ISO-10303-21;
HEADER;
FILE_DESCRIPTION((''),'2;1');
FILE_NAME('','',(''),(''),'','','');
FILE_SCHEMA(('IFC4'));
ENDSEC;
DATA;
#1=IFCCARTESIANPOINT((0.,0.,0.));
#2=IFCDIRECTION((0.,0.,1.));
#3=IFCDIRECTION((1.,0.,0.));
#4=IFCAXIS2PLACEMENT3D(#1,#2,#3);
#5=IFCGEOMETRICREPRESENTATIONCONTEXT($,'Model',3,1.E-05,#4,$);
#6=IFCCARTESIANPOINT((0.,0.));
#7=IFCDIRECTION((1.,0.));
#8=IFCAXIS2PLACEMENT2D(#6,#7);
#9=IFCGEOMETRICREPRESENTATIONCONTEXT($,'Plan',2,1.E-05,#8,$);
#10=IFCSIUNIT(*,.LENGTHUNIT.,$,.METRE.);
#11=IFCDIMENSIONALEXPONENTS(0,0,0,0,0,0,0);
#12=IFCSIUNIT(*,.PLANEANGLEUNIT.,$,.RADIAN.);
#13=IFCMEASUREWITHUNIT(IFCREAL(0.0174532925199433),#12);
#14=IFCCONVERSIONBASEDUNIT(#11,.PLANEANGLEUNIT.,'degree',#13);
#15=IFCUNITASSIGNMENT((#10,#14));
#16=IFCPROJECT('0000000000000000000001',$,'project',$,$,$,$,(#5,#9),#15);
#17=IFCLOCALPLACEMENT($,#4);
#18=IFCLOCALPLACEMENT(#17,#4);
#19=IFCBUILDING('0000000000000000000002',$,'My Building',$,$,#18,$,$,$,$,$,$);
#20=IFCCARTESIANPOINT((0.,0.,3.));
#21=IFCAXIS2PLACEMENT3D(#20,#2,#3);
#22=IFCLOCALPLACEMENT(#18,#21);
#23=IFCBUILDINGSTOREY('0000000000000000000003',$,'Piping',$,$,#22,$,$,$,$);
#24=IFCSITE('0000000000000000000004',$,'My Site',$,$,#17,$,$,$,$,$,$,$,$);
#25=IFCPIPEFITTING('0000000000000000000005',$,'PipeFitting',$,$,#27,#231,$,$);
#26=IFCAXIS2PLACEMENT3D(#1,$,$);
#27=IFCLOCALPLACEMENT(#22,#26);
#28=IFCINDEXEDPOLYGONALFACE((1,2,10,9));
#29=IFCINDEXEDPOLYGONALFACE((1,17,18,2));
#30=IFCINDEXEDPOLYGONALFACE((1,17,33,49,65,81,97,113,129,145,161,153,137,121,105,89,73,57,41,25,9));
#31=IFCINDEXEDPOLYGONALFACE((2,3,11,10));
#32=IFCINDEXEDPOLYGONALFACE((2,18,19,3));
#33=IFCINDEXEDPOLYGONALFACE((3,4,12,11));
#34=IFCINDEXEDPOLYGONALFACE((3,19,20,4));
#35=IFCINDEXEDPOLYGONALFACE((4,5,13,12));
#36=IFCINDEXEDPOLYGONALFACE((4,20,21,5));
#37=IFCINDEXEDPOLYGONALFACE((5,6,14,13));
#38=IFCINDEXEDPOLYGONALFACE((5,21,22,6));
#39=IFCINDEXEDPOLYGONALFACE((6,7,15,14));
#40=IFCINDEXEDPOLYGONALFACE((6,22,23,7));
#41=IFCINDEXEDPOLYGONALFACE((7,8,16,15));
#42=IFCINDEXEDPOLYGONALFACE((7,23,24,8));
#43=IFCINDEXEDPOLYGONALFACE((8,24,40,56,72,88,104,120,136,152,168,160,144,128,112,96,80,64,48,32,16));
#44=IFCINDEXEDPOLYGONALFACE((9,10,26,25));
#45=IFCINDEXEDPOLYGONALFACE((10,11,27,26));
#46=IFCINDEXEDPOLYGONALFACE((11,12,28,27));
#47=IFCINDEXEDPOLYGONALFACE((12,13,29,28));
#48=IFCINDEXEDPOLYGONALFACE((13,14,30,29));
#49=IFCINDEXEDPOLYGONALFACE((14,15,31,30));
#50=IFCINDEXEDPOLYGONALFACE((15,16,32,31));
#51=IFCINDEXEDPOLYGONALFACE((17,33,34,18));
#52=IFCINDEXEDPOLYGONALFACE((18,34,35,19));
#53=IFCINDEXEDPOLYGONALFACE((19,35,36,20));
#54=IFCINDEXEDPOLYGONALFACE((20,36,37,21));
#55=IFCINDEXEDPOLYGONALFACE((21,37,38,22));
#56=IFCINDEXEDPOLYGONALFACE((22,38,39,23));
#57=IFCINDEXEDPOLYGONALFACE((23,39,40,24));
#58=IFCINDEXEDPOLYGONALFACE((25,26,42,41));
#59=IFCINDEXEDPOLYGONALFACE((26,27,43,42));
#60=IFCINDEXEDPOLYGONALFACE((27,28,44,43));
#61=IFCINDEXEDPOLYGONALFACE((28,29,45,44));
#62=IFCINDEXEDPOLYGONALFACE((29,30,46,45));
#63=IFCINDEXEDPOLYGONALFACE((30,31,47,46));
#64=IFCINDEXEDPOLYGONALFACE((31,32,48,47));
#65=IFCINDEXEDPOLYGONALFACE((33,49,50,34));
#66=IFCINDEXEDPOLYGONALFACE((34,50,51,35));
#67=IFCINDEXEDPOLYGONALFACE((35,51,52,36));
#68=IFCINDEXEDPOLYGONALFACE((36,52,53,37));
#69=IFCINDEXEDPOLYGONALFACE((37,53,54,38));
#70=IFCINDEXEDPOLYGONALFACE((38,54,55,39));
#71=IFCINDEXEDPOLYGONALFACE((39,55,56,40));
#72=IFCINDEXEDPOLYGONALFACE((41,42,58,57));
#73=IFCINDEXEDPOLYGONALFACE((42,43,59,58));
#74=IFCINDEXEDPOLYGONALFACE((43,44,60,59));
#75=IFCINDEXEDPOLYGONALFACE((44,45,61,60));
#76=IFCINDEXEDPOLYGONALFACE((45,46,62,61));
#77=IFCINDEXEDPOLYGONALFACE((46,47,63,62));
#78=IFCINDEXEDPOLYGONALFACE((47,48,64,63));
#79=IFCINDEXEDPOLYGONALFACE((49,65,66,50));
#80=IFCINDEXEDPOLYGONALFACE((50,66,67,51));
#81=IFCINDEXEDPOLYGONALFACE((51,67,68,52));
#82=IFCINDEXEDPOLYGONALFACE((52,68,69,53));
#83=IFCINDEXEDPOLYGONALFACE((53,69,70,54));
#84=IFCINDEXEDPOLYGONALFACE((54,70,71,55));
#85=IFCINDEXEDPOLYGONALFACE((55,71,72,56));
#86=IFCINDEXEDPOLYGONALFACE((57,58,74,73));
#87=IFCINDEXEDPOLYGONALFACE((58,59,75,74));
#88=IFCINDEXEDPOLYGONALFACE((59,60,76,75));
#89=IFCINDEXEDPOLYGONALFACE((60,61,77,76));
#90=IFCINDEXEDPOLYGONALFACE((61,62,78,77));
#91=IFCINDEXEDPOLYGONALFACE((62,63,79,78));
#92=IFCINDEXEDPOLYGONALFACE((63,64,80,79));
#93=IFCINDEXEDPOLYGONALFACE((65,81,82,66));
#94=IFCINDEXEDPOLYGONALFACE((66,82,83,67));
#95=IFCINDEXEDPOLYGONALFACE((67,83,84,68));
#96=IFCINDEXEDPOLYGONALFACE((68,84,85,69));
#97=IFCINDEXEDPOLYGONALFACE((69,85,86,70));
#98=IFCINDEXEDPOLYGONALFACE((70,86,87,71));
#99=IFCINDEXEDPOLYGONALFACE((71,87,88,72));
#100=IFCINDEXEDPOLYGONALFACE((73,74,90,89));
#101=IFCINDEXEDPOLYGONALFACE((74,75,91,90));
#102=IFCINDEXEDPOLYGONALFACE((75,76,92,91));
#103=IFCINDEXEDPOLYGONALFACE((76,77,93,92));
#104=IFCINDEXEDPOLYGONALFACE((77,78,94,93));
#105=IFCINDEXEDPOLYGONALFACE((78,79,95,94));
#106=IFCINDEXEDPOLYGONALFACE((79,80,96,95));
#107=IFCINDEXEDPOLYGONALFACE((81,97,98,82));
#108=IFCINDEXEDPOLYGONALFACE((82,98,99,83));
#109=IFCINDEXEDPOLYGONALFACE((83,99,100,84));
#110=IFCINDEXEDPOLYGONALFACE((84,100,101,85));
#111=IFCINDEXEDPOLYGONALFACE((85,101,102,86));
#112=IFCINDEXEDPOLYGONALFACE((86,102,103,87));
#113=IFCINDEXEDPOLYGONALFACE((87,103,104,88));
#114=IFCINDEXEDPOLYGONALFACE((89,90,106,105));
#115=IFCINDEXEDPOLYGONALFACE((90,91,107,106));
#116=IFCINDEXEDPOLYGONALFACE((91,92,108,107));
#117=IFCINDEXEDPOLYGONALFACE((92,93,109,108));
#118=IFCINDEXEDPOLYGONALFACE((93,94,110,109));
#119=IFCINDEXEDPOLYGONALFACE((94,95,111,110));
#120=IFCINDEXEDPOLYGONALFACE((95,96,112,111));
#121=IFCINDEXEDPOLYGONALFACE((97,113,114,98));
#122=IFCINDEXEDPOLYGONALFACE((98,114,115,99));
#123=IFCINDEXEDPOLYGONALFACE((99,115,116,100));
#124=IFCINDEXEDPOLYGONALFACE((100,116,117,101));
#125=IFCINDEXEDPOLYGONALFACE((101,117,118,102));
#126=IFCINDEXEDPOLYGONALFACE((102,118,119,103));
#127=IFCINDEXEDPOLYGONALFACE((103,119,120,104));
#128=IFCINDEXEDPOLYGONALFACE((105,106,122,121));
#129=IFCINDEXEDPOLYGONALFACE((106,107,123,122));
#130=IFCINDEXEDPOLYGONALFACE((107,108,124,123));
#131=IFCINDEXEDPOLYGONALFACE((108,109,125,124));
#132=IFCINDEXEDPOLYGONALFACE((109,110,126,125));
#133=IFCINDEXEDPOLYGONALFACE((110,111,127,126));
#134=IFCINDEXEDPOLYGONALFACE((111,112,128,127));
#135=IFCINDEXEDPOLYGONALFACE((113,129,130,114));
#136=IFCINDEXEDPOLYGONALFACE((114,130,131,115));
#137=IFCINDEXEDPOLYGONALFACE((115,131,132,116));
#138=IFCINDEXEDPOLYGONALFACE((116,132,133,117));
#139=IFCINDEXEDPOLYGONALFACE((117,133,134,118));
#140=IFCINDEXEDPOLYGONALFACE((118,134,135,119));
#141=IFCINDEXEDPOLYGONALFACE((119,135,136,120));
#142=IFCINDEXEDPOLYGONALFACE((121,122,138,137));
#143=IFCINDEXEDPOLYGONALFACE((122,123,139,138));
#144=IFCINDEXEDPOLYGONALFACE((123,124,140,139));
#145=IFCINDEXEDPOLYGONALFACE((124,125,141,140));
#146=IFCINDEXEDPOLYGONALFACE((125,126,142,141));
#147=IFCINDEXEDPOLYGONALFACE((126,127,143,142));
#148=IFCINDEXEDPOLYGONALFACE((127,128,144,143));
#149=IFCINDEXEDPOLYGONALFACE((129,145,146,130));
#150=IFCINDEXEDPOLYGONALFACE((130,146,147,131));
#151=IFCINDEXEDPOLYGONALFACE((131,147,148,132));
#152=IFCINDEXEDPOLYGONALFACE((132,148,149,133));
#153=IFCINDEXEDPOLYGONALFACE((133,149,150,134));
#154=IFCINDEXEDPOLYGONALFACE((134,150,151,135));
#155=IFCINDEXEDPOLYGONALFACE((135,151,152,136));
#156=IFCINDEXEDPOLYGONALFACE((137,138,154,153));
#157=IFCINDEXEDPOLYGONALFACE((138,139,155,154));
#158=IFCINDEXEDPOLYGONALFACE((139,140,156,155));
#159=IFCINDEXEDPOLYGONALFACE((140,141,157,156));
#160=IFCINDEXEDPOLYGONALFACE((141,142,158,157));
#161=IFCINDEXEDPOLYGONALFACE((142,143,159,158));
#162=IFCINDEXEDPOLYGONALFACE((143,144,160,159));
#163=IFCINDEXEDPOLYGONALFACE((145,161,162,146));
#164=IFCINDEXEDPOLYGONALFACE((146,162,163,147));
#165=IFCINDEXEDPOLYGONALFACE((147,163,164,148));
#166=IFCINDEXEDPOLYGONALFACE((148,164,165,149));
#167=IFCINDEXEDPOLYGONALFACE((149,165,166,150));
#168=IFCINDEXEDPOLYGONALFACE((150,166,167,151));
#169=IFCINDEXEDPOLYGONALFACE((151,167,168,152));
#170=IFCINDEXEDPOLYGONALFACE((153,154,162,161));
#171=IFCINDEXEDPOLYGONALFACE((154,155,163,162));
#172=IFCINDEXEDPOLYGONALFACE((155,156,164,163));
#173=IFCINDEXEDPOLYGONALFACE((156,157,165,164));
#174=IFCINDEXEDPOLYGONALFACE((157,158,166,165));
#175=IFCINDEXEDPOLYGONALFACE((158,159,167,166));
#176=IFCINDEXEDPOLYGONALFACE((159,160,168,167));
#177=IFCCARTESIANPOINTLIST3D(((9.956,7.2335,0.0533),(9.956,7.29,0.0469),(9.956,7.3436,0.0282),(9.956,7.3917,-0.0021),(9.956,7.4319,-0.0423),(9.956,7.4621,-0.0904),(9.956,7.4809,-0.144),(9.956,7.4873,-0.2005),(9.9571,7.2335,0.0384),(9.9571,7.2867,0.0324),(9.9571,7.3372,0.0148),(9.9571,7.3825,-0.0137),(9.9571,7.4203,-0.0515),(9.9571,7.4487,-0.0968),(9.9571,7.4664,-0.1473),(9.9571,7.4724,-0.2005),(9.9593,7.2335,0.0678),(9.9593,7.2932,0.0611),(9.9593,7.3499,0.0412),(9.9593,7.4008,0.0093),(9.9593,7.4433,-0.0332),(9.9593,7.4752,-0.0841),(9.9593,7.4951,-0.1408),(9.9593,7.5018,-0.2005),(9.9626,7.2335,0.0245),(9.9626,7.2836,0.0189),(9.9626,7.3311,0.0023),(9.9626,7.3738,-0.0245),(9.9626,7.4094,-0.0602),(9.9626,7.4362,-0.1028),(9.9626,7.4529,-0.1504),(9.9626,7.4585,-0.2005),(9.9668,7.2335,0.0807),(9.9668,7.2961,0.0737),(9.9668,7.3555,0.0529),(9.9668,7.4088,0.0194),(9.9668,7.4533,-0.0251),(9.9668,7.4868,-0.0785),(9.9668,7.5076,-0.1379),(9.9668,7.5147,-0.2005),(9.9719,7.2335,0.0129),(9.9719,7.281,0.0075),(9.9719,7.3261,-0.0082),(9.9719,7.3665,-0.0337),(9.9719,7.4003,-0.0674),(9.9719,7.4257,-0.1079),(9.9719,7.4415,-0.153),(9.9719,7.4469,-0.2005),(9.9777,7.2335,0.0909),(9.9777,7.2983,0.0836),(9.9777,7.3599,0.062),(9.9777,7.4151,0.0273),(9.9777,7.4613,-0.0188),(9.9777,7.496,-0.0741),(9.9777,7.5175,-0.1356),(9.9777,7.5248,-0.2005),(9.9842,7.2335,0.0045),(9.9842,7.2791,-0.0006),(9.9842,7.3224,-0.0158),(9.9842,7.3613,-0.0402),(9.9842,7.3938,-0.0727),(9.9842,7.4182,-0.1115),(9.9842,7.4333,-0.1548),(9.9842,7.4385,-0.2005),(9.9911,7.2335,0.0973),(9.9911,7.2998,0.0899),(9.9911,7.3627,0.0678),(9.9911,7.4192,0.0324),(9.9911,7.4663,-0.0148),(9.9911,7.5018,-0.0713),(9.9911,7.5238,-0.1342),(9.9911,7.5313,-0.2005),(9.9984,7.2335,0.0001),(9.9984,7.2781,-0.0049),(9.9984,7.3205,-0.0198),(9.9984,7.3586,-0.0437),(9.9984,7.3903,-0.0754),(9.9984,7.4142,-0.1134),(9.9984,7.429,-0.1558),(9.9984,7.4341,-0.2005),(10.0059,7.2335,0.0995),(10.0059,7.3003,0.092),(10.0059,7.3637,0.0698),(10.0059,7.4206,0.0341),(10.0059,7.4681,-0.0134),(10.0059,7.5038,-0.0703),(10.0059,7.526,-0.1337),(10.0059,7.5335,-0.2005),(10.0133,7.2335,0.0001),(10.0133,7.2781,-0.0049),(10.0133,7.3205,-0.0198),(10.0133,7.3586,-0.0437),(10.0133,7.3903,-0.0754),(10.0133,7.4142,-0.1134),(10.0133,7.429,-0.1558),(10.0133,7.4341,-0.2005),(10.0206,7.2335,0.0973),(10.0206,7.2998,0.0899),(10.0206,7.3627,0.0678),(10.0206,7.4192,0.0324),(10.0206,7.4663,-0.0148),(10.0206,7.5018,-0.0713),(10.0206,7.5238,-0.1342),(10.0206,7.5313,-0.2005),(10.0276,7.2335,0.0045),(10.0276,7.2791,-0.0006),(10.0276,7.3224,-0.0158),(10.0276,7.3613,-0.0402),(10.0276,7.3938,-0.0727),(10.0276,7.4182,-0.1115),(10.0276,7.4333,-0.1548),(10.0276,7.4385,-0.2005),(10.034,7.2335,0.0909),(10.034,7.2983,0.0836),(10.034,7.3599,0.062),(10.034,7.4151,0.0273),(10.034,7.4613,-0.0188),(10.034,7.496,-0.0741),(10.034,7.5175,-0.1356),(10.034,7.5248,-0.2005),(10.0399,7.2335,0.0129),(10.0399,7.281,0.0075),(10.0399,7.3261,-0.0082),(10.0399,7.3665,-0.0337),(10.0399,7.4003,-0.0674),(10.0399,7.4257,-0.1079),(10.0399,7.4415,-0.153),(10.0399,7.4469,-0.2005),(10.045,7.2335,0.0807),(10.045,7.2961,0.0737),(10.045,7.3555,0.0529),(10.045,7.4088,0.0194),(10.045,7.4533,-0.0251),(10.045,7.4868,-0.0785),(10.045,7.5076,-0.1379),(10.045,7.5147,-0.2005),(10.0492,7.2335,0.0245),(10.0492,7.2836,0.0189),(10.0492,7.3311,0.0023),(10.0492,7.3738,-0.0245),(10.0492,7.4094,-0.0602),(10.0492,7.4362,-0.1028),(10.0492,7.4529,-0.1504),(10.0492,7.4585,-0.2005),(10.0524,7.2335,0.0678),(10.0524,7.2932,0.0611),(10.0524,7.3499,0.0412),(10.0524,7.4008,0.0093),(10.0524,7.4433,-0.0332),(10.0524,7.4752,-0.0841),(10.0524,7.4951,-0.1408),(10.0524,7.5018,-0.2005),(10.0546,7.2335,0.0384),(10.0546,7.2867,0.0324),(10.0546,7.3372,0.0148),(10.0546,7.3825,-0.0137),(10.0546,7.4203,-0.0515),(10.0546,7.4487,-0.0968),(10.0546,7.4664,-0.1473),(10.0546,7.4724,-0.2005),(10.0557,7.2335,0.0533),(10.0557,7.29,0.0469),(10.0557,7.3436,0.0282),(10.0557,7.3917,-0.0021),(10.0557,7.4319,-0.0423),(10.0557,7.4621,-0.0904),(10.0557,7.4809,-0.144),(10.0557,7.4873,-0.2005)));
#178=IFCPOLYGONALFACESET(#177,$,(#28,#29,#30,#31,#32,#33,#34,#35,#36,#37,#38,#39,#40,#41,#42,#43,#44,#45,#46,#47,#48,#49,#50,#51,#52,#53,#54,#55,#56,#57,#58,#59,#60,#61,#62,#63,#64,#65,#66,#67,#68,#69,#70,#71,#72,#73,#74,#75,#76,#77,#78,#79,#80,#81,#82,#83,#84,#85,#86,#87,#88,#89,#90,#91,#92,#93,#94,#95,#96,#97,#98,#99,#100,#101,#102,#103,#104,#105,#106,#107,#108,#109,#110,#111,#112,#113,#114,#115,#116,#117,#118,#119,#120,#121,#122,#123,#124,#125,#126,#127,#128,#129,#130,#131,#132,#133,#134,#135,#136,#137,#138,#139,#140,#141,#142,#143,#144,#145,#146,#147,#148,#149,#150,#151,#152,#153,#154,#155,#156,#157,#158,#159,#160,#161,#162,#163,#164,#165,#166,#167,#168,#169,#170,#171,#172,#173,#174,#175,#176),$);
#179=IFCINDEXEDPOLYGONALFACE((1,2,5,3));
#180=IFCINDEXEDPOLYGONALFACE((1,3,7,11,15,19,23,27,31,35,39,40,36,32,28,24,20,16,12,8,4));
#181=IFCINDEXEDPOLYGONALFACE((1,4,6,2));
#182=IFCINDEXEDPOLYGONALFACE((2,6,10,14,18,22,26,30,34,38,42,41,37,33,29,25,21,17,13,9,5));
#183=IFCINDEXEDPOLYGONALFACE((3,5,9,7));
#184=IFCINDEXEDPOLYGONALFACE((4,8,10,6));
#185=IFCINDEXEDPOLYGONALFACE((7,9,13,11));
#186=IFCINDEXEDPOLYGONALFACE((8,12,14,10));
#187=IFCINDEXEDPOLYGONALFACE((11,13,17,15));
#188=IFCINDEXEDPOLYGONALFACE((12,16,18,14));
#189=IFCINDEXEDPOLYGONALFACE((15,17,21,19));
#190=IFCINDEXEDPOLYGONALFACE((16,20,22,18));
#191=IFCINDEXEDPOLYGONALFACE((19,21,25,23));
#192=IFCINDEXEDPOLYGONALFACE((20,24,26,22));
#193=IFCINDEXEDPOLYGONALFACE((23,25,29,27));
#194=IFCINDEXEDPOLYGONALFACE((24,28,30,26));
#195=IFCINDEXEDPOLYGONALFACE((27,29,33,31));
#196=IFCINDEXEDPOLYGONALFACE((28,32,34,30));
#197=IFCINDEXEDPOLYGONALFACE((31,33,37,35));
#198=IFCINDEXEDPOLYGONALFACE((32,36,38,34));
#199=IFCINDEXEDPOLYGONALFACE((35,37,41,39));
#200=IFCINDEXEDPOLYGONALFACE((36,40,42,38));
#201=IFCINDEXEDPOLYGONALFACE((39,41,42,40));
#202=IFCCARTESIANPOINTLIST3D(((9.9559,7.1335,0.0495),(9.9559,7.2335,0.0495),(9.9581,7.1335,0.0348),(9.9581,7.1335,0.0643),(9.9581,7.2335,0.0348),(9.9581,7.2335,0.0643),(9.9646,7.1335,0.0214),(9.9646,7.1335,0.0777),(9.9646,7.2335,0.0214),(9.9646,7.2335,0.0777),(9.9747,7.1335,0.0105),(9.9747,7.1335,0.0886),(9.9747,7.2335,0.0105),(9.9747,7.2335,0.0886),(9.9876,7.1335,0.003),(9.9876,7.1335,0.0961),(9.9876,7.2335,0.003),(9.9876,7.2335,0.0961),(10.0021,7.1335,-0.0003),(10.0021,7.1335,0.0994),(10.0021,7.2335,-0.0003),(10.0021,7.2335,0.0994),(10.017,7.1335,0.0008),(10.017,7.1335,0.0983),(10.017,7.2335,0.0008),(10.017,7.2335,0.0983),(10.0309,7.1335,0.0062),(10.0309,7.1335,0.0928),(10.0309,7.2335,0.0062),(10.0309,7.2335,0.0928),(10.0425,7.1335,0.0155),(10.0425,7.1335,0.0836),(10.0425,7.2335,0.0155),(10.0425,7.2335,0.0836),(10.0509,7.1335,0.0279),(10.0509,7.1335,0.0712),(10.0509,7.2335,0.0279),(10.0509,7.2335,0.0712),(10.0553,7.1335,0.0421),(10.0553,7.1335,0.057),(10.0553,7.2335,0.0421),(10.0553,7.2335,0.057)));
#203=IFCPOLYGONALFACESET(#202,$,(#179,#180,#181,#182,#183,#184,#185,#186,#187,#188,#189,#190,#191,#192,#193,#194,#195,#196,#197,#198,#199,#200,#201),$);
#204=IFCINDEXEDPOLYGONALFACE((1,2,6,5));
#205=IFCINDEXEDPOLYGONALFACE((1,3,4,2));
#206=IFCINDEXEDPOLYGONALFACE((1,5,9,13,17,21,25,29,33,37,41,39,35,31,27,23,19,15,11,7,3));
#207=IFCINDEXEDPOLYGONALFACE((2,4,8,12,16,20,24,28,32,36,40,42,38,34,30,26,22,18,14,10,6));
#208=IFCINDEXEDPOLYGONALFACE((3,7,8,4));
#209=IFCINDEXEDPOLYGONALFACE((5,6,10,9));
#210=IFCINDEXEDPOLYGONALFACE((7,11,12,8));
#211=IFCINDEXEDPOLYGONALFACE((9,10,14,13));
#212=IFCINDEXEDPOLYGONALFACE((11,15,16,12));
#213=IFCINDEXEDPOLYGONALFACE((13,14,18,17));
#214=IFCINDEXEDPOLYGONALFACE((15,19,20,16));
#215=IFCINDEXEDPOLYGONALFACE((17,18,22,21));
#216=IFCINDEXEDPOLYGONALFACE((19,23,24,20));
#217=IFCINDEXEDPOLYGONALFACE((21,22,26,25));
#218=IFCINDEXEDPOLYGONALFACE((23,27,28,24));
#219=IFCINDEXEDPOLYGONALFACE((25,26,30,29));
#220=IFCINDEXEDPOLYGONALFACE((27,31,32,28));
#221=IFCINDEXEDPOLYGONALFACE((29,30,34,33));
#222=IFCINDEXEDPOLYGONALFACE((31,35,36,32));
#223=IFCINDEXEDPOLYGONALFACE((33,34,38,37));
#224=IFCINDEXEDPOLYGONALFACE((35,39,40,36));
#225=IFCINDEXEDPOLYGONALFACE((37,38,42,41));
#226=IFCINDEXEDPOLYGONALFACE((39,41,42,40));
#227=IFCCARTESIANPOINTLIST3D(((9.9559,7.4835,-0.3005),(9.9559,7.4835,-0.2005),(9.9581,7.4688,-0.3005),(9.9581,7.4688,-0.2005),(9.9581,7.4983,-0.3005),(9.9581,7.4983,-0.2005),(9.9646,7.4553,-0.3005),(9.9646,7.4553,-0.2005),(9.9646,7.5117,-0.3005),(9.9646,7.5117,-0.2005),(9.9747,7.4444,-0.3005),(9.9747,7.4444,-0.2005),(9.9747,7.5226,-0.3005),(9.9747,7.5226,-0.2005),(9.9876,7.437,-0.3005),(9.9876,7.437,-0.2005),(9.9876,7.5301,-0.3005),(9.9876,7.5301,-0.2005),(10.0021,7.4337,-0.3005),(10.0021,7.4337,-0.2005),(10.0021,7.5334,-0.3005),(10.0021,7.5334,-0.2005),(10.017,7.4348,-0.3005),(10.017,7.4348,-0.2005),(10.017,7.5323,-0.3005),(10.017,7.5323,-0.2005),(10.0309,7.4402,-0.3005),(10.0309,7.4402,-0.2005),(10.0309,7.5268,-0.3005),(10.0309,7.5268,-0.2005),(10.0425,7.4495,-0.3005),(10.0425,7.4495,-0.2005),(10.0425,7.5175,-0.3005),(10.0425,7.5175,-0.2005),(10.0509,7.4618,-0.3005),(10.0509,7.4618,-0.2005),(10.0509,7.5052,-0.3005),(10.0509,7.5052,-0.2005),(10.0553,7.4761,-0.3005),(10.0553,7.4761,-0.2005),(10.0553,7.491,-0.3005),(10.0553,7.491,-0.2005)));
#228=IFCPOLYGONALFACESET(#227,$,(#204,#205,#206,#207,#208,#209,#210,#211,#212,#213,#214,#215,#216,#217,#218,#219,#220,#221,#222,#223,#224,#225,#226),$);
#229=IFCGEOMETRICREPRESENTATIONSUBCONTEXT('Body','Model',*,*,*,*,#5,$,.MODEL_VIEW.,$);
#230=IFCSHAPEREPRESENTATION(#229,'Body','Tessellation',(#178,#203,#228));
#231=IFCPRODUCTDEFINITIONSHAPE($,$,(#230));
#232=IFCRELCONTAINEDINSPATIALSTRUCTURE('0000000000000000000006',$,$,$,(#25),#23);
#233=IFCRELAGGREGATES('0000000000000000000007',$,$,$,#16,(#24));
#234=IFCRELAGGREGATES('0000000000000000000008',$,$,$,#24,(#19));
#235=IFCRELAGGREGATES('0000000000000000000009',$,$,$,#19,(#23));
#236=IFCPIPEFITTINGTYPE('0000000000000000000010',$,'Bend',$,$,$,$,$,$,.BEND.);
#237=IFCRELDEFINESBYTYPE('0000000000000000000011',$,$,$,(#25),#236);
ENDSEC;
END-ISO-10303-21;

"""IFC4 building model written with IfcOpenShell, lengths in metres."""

from ifc_helpers import new_model, entity, si_unit, converted_unit, frame, origin_with_axes, origin_2d_with_axis, place, context, subcontext, project, spatial, circle, extrude, source, transform, mapped, type_object, type_shapes, element, save


model = new_model("IFC4")

# Units and contexts
model_context = context("Model", 3, precision=1e-05, world=origin_with_axes())
plan_context = context("Plan", 2, precision=1e-05, world=origin_2d_with_axis())
body_context = subcontext(model_context, "Body", "Model", "MODEL_VIEW")
ifc_project = project(units=[si_unit("LENGTHUNIT", "METRE"), converted_unit("PLANEANGLEUNIT", "degree", entity("IfcReal", 0.0174532925199433), si_unit("PLANEANGLEUNIT", "RADIAN"), dimensions=[0, 0, 0, 0, 0, 0, 0])], contexts=[model_context, plan_context])

# Site, building, storey
site_placement = place(None, origin_with_axes())
site = spatial("IfcSite", under=ifc_project, at=site_placement, Name="My Site")
building_placement = place(site_placement, origin_with_axes())
building = spatial("IfcBuilding", under=site, at=building_placement, Name="My Building")
storey_placement = place(building_placement, frame((0.0, 0.0, 3.0), z_axis=(0.0, 0.0, 1.0), x_axis=(1.0, 0.0, 0.0)))
storey = spatial("IfcBuildingStorey", under=building, at=storey_placement, Name="Piping")

# Pipe fitting
pipe_fitting_type = type_object("IfcPipeFittingType", Name="Bend", PredefinedType="BEND")
shared_shape = source(origin_with_axes(), body_context, "Body", "SolidModel", [
    entity("IfcSweptDiskSolid", entity("IfcIndexedPolyCurve", entity("IfcCartesianPointList3D", [[0.0, 0.0, 0.1], [0.0, -0.0732, 0.2768], [0.0, -0.25, 0.35]]), [entity("IfcArcIndex", [1, 2, 3])]), 0.05),
    extrude(circle(Radius=0.05), origin_with_axes(), (0.0, 0.0, 1.0), 0.1),
    extrude(circle(Radius=0.05), frame((0.0, -0.25, 0.35), z_axis=(0.0, -1.0, 0.0), x_axis=(1.0, 0.0, 0.0)), (0.0, 0.0, 1.0), 0.1),
])
type_shapes(pipe_fitting_type, [shared_shape])
for number, where, z_axis, x_axis, name in (
    (1, (10.0059, 7.1335, 0.0495), (0.0, 1.0, 0.0), (-1.0, 0.0, 0.0), "PipeFitting"),
):
    element("IfcPipeFitting", number, at=place(storey_placement, frame(where, z_axis=z_axis, x_axis=x_axis)), inside=storey, type_object=pipe_fitting_type, Name=name, context=body_context, shape_type="MappedRepresentation", body=[
        mapped(shared_shape, transform((0.0, 0.0, 0.0), x_axis=(1.0, 0.0, 0.0), y_axis=(0.0, 1.0, 0.0), z_axis=(0.0, 0.0, 1.0), scale=1.0)),
    ])

save(model, "model.ifc")
